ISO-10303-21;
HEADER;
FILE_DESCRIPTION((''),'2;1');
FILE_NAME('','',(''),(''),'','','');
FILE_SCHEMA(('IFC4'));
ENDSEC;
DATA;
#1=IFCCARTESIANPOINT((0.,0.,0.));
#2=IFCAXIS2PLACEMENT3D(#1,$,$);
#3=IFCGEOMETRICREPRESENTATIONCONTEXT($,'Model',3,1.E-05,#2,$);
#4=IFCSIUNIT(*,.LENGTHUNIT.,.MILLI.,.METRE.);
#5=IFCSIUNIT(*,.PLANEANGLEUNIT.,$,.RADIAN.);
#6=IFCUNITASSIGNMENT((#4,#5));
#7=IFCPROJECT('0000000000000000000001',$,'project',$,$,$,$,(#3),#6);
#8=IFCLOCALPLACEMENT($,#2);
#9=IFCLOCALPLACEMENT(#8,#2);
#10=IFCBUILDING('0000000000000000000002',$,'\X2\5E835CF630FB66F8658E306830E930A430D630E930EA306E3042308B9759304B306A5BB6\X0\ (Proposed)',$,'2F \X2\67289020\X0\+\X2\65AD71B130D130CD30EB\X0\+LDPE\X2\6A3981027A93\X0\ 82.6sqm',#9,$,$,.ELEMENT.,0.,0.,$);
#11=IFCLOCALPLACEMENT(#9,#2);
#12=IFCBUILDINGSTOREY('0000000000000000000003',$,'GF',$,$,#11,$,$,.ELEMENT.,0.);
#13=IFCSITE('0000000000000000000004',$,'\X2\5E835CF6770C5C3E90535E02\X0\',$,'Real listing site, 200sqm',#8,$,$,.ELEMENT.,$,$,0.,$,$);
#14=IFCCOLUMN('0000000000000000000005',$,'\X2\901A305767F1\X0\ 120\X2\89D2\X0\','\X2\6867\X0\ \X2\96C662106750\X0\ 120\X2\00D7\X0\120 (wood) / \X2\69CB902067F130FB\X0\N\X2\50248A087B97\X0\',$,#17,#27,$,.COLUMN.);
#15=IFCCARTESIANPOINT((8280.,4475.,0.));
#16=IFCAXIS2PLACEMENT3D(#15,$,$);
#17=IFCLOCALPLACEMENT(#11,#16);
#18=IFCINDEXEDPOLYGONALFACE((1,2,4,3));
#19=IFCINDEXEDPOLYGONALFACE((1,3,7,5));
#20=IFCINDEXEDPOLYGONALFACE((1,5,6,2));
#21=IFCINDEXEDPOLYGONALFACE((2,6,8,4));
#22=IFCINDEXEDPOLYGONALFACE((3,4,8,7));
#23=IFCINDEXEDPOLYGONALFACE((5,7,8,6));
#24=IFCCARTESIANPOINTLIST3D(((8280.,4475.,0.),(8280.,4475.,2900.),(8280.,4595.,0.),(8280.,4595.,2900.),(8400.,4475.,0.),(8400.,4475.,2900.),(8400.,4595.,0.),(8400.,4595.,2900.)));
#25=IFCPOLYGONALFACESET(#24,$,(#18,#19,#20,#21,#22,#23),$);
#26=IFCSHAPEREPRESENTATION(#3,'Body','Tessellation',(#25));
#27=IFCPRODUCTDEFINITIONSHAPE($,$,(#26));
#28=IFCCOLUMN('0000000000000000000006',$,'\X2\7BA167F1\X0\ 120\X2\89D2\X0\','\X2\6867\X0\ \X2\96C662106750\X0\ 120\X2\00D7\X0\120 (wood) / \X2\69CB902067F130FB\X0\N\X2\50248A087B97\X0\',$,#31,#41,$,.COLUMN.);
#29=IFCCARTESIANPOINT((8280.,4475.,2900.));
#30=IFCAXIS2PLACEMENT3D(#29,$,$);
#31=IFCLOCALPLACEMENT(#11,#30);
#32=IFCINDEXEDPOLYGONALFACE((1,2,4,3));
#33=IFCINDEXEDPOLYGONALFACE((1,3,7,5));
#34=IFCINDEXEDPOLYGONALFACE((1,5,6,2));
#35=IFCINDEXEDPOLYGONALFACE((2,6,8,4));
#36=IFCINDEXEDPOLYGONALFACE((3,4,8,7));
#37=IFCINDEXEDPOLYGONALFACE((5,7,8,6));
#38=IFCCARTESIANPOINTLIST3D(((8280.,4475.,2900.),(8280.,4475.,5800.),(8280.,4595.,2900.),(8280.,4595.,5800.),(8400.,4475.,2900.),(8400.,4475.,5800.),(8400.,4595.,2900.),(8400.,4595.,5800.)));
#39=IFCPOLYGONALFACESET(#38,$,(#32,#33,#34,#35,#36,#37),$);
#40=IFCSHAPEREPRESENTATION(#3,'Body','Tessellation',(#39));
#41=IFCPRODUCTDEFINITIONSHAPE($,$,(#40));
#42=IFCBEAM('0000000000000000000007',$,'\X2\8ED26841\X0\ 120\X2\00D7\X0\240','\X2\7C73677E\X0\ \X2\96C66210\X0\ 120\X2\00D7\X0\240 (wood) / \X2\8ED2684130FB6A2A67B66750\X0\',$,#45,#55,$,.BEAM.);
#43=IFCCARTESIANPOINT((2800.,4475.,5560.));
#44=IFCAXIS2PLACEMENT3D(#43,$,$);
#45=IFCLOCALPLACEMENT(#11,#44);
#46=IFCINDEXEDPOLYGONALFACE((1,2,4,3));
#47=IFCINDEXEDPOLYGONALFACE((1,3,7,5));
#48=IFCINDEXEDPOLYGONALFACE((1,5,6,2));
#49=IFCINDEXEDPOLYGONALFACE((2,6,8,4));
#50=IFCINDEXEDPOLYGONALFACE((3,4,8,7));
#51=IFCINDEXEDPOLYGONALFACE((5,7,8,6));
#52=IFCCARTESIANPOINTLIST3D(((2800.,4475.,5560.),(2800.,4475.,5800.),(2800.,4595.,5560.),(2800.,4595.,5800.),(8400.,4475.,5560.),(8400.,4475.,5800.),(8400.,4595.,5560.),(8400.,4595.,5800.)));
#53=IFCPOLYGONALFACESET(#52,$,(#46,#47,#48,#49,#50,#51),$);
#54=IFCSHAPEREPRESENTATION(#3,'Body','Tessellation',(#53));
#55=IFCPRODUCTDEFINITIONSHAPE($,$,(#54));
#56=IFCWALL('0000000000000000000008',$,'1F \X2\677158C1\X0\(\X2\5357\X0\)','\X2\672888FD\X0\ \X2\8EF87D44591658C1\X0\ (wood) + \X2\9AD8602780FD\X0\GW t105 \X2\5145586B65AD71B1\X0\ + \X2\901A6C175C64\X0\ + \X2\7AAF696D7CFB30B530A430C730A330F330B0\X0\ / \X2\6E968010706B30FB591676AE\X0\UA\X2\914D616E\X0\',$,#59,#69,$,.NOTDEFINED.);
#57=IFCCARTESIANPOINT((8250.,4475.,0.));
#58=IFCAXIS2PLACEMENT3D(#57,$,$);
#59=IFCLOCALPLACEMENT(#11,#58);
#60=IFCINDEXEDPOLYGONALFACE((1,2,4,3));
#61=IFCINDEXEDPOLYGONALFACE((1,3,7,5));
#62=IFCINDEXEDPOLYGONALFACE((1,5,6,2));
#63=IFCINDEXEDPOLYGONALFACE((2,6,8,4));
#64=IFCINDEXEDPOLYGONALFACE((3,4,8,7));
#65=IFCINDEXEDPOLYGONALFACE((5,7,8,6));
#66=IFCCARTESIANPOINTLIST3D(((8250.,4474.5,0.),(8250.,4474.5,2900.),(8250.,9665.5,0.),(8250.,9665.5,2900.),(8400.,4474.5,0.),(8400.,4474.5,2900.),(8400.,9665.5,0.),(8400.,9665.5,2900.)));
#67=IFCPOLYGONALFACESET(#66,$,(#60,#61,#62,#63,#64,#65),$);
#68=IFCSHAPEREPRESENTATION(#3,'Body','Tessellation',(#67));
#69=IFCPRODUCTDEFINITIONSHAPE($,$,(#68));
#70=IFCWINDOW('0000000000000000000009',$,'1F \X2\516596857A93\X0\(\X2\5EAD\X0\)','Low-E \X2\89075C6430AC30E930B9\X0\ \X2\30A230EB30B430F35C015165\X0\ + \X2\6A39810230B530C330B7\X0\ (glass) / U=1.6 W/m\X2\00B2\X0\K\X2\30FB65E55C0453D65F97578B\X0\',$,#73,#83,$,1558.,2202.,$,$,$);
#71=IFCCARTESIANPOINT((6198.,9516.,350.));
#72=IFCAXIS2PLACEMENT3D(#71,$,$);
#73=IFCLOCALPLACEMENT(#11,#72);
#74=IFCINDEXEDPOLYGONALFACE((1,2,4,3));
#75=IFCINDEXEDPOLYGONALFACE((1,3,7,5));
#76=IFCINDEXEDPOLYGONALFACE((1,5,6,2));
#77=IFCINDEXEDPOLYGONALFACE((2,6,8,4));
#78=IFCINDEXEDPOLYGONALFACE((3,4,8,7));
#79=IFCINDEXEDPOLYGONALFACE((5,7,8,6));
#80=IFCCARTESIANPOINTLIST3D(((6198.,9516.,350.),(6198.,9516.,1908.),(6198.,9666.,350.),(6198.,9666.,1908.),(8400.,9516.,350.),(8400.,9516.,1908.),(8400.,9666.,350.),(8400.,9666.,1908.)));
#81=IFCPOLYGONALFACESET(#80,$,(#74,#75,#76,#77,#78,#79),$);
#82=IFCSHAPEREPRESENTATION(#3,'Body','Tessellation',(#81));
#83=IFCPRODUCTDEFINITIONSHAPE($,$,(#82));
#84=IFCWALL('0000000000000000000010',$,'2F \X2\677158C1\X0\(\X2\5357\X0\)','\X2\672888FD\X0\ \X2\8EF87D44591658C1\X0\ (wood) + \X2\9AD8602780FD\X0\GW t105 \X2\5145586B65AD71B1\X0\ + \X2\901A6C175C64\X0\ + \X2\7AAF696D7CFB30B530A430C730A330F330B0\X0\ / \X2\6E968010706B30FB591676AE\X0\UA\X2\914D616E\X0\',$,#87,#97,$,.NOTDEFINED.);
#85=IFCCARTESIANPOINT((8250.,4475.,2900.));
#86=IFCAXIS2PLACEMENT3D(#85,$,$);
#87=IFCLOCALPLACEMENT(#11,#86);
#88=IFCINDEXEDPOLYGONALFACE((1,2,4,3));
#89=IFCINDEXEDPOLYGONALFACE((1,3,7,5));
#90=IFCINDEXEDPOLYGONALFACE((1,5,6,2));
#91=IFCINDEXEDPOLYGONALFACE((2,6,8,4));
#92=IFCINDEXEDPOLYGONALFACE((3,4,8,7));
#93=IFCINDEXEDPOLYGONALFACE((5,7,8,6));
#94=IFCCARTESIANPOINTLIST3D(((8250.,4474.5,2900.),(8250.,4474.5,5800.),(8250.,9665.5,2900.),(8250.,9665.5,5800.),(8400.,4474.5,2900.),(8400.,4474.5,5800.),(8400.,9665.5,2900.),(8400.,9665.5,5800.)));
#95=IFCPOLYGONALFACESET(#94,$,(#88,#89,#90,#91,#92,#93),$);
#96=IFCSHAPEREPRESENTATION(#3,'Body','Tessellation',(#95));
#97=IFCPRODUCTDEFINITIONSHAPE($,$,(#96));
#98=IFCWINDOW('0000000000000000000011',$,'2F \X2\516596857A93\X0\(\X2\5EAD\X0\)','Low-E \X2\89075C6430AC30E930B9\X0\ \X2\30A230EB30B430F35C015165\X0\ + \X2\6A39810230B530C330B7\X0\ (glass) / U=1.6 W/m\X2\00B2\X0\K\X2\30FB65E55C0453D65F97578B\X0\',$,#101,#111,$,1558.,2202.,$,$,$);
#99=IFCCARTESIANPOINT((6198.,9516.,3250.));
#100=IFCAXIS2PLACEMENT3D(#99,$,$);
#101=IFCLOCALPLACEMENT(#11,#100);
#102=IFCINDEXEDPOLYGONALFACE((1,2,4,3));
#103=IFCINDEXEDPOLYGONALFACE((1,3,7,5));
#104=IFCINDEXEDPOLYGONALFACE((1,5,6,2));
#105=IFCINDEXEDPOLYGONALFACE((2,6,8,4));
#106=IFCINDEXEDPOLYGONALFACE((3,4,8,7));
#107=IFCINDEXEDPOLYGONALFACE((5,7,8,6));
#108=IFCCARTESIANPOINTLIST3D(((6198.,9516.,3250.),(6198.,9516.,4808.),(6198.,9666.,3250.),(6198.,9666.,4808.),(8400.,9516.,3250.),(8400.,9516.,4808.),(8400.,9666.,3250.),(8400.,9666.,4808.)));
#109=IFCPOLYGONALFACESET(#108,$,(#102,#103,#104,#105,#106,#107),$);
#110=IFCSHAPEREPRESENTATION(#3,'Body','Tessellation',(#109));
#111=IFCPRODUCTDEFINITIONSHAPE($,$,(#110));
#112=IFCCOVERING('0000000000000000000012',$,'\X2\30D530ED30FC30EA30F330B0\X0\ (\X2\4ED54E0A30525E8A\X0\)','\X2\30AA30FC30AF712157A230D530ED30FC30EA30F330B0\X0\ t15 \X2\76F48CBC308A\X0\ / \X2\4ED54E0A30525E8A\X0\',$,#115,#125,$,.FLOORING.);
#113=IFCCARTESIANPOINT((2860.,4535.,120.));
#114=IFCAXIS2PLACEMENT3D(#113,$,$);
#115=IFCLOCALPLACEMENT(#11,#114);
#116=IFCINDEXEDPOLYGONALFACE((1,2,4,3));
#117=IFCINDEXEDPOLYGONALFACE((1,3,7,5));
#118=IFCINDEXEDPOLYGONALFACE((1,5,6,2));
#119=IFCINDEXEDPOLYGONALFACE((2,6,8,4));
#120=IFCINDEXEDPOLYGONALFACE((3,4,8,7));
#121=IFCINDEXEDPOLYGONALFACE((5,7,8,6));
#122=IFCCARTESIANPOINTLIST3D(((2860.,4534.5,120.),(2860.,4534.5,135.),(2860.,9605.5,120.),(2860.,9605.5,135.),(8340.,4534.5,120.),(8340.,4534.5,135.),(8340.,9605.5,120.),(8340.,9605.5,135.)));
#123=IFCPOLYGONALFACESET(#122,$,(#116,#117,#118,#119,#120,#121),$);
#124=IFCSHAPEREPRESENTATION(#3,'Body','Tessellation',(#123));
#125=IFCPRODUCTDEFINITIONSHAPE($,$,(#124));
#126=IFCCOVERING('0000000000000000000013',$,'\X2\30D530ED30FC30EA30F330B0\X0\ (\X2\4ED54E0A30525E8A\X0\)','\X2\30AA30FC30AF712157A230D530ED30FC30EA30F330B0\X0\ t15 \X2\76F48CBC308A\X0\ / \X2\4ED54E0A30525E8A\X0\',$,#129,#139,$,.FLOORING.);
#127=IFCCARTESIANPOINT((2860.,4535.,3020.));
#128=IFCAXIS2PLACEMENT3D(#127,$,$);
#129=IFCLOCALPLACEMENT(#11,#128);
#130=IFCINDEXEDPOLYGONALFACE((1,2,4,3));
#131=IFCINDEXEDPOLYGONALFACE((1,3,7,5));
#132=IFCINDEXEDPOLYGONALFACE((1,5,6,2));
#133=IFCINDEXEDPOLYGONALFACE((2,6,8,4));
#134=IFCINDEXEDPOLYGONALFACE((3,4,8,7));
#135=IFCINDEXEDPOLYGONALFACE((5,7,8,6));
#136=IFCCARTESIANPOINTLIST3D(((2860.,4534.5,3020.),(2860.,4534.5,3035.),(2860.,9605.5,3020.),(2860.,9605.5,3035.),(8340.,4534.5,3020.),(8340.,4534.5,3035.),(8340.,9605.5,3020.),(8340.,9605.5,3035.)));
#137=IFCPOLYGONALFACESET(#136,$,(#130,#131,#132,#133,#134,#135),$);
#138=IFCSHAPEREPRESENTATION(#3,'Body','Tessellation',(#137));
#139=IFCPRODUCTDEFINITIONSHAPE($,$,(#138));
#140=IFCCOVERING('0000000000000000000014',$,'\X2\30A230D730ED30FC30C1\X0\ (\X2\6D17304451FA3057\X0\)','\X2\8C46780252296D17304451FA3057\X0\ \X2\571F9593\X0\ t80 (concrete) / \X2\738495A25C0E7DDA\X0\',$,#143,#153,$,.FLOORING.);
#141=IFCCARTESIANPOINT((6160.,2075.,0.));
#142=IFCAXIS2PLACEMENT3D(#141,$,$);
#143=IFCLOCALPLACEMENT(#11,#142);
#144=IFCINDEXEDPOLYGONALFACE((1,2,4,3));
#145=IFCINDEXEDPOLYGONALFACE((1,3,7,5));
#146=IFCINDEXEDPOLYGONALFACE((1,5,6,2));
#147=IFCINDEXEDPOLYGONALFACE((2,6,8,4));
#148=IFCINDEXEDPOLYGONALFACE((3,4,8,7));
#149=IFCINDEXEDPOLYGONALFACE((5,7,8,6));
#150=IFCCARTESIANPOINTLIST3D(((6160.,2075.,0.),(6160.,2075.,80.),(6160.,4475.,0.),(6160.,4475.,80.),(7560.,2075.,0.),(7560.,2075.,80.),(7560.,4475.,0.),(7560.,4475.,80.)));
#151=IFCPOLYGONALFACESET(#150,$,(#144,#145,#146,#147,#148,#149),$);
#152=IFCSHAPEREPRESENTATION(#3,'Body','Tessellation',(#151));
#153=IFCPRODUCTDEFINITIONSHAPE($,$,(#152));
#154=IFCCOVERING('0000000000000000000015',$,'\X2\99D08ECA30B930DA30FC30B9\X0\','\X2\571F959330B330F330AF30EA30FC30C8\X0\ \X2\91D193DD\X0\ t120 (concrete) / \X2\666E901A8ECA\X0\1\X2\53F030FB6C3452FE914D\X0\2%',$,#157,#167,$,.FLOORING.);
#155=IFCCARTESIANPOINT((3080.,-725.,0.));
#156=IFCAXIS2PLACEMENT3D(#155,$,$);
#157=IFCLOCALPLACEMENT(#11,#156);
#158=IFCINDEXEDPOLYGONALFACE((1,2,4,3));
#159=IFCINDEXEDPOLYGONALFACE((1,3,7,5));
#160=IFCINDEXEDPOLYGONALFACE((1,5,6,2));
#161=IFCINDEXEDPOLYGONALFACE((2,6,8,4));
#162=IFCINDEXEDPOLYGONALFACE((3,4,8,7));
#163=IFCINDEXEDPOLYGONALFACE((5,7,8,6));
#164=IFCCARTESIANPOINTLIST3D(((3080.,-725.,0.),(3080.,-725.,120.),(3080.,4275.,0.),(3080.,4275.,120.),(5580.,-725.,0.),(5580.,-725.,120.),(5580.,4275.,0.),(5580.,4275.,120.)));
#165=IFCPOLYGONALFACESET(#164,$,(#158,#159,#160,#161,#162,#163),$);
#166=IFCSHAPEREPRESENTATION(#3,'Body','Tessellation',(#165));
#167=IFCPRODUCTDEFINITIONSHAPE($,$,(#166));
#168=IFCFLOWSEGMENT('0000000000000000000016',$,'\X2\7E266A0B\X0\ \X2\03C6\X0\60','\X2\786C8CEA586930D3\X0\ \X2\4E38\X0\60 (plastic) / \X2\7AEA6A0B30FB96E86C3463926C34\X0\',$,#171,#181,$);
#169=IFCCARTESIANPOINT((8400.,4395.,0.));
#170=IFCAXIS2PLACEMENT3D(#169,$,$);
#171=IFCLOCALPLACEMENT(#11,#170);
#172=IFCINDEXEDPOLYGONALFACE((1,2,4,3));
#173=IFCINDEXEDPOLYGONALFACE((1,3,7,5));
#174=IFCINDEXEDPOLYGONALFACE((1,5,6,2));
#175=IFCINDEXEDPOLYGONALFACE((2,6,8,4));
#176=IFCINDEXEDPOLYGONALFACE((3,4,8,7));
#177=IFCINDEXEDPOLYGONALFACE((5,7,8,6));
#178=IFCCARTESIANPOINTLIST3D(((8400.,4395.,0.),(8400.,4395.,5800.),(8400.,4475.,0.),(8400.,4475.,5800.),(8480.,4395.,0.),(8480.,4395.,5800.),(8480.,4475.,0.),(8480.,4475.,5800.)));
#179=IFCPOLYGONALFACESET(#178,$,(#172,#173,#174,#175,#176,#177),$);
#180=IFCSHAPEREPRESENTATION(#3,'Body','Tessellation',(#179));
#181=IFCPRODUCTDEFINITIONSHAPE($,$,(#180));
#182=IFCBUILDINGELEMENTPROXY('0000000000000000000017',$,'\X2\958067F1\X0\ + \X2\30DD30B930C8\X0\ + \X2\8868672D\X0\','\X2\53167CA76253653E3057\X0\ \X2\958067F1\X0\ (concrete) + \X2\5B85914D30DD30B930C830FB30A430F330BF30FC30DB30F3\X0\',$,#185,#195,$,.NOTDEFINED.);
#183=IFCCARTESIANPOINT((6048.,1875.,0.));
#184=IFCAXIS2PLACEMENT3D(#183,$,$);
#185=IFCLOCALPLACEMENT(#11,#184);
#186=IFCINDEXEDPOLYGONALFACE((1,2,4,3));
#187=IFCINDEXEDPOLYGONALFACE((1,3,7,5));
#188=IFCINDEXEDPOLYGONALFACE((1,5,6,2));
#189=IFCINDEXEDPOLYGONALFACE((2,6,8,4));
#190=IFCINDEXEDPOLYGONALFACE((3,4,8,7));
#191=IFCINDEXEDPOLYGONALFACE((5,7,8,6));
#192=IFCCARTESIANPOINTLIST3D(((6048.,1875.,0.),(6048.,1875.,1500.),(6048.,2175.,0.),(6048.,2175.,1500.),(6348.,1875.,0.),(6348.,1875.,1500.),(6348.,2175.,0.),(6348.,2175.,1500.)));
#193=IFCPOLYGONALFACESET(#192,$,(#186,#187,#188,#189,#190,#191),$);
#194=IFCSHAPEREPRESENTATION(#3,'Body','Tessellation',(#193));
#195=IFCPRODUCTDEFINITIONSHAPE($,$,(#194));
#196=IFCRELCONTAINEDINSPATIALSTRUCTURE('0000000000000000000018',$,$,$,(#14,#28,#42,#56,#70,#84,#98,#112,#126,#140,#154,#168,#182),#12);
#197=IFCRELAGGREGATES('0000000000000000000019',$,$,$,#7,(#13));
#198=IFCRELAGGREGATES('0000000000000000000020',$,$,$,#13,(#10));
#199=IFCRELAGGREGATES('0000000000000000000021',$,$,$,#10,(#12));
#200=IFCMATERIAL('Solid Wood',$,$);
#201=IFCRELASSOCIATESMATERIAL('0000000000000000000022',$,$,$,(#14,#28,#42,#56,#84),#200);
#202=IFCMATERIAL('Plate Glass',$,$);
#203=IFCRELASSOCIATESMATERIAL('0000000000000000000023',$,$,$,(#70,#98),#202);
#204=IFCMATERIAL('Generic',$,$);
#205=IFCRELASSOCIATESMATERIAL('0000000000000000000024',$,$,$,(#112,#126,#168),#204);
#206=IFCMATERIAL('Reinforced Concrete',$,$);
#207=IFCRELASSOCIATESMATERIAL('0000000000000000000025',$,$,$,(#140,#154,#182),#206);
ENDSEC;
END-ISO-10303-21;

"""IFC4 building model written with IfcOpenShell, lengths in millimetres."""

from ifc_helpers import new_model, si_unit, frame, frame_2d, origin, place, context, project, spatial, rectangle, extrude, material, element, fill, save


model = new_model("IFC4")

# Units and contexts
model_context = context("Model", 3, precision=1e-05, world=origin())
ifc_project = project(units=[si_unit("LENGTHUNIT", "METRE", prefix="MILLI"), si_unit("PLANEANGLEUNIT", "RADIAN")], contexts=[model_context])

# Site, building, storey
site_placement = place(None, origin())
site = spatial("IfcSite", under=ifc_project, at=site_placement, Name="広島県尾道市", ObjectType="Real listing site, 200sqm", CompositionType="ELEMENT", RefElevation=0.0)
building_placement = place(site_placement, origin())
building = spatial("IfcBuilding", under=site, at=building_placement, Name="広島・書斎とライブラリのある静かな家 (Proposed)", ObjectType="2F 木造+断熱パネル+LDPE樹脂窓 82.6sqm", CompositionType="ELEMENT", ElevationOfRefHeight=0.0, ElevationOfTerrain=0.0)
storey_placement = place(building_placement, origin())
storey = spatial("IfcBuildingStorey", under=building, at=storey_placement, Name="GF", CompositionType="ELEMENT", Elevation=0.0)

# Columns
ifc_material_1 = material(Name="Solid Wood")
column_1_placement = place(storey_placement, frame((8280.0, 4475.0, 0.0)))
element("IfcColumn", 1, at=column_1_placement, inside=storey, material=ifc_material_1, Name="通し柱 120角", Description="桧 集成材 120×120 (wood) / 構造柱・N値計算", PredefinedType="COLUMN", context=model_context, shape_type="SweptSolid", body=[
    extrude(rectangle(XDim=120.0, YDim=120.0, at=frame_2d((60.0, 60.0))), frame((8280.0, 4475.0, 0.0)), (0.0, 0.0, 1.0), 2900.0),
])
column_2_placement = place(storey_placement, frame((8280.0, 4475.0, 2900.0)))
element("IfcColumn", 2, at=column_2_placement, inside=storey, material=ifc_material_1, Name="管柱 120角", Description="桧 集成材 120×120 (wood) / 構造柱・N値計算", PredefinedType="COLUMN", context=model_context, shape_type="SweptSolid", body=[
    extrude(rectangle(XDim=120.0, YDim=120.0, at=frame_2d((60.0, 60.0))), frame((8280.0, 4475.0, 2900.0)), (0.0, 0.0, 1.0), 2900.0),
])

# Beam
beam_1_placement = place(storey_placement, frame((2800.0, 4475.0, 5560.0)))
element("IfcBeam", 3, at=beam_1_placement, inside=storey, material=ifc_material_1, Name="軒桁 120×240", Description="米松 集成 120×240 (wood) / 軒桁・横架材", PredefinedType="BEAM", context=model_context, shape_type="SweptSolid", body=[
    extrude(rectangle(XDim=5600.0, YDim=120.0, at=frame_2d((2800.0, 60.0))), frame((2800.0, 4475.0, 5560.0)), (0.0, 0.0, 1.0), 240.0),
])

# Wall, opening, window
wall_1_placement = place(storey_placement, frame((8250.0, 4475.0, 0.0)))
wall_1 = element("IfcWall", 4, at=wall_1_placement, inside=storey, material=ifc_material_1, Name="1F 東壁(南)", Description="木製 軸組外壁 (wood) + 高性能GW t105 充填断熱 + 通気層 + 窯業系サイディング / 準耐火・外皮UA配慮", PredefinedType="NOTDEFINED", context=model_context, shape_type="SweptSolid", body=[
    extrude(rectangle(XDim=150.0, YDim=5191.0, at=frame_2d((75.0, 2595.0))), frame((8250.0, 4475.0, 0.0)), (0.0, 0.0, 1.0), 2900.0),
])
opening_1_placement = place(storey_placement, frame((6198.0, 9516.0, 350.0)))
opening_1 = element("IfcOpeningElement", 5, at=opening_1_placement, cuts=wall_1, PredefinedType="NOTDEFINED", context=model_context, shape_type="SweptSolid", body=[
    extrude(rectangle(XDim=2202.0, YDim=150.0, at=frame_2d((1101.0, 75.0))), frame((6198.0, 9516.0, 350.0)), (0.0, 0.0, 1.0), 1558.0),
])
ifc_material_2 = material(Name="Plate Glass")
window_1_placement = place(storey_placement, frame((6198.0, 9516.0, 350.0)))
window_1 = element("IfcWindow", 6, at=window_1_placement, inside=storey, material=ifc_material_2, Name="1F 入隅窓(庭)", Description="Low-E 複層ガラス アルゴン封入 + 樹脂サッシ (glass) / U=1.6 W/m²K・日射取得型", OverallHeight=1558.0, OverallWidth=2202.0, context=model_context, shape_type="SweptSolid", body=[
    extrude(rectangle(XDim=2202.0, YDim=150.0, at=frame_2d((1101.0, 75.0))), frame((6198.0, 9516.0, 350.0)), (0.0, 0.0, 1.0), 1558.0),
])
fill(opening_1, window_1)

# Wall, opening, window
wall_2_placement = place(storey_placement, frame((8250.0, 4475.0, 2900.0)))
wall_2 = element("IfcWall", 7, at=wall_2_placement, inside=storey, material=ifc_material_1, Name="2F 東壁(南)", Description="木製 軸組外壁 (wood) + 高性能GW t105 充填断熱 + 通気層 + 窯業系サイディング / 準耐火・外皮UA配慮", PredefinedType="NOTDEFINED", context=model_context, shape_type="SweptSolid", body=[
    extrude(rectangle(XDim=150.0, YDim=5191.0, at=frame_2d((75.0, 2595.0))), frame((8250.0, 4475.0, 2900.0)), (0.0, 0.0, 1.0), 2900.0),
])
opening_2_placement = place(storey_placement, frame((6198.0, 9516.0, 3250.0)))
opening_2 = element("IfcOpeningElement", 8, at=opening_2_placement, cuts=wall_2, PredefinedType="NOTDEFINED", context=model_context, shape_type="SweptSolid", body=[
    extrude(rectangle(XDim=2202.0, YDim=150.0, at=frame_2d((1101.0, 75.0))), frame((6198.0, 9516.0, 3250.0)), (0.0, 0.0, 1.0), 1558.0),
])
window_2_placement = place(storey_placement, frame((6198.0, 9516.0, 3250.0)))
window_2 = element("IfcWindow", 9, at=window_2_placement, inside=storey, material=ifc_material_2, Name="2F 入隅窓(庭)", Description="Low-E 複層ガラス アルゴン封入 + 樹脂サッシ (glass) / U=1.6 W/m²K・日射取得型", OverallHeight=1558.0, OverallWidth=2202.0, context=model_context, shape_type="SweptSolid", body=[
    extrude(rectangle(XDim=2202.0, YDim=150.0, at=frame_2d((1101.0, 75.0))), frame((6198.0, 9516.0, 3250.0)), (0.0, 0.0, 1.0), 1558.0),
])
fill(opening_2, window_2)

# Coverings
ifc_material_3 = material(Name="Generic")
covering_1_placement = place(storey_placement, frame((2860.0, 4535.0, 120.0)))
element("IfcCovering", 10, at=covering_1_placement, inside=storey, material=ifc_material_3, Name="フローリング (仕上げ床)", Description="オーク無垢フローリング t15 直貼り / 仕上げ床", PredefinedType="FLOORING", context=model_context, shape_type="SweptSolid", body=[
    extrude(rectangle(XDim=5480.0, YDim=5071.0, at=frame_2d((2740.0, 2535.0))), frame((2860.0, 4535.0, 120.0)), (0.0, 0.0, 1.0), 15.0),
])
covering_2_placement = place(storey_placement, frame((2860.0, 4535.0, 3020.0)))
element("IfcCovering", 11, at=covering_2_placement, inside=storey, material=ifc_material_3, Name="フローリング (仕上げ床)", Description="オーク無垢フローリング t15 直貼り / 仕上げ床", PredefinedType="FLOORING", context=model_context, shape_type="SweptSolid", body=[
    extrude(rectangle(XDim=5480.0, YDim=5071.0, at=frame_2d((2740.0, 2535.0))), frame((2860.0, 4535.0, 3020.0)), (0.0, 0.0, 1.0), 15.0),
])
ifc_material_4 = material(Name="Reinforced Concrete")
covering_3_placement = place(storey_placement, frame((6160.0, 2075.0, 0.0)))
element("IfcCovering", 12, at=covering_3_placement, inside=storey, material=ifc_material_4, Name="アプローチ (洗い出し)", Description="豆砂利洗い出し 土間 t80 (concrete) / 玄関導線", PredefinedType="FLOORING", context=model_context, shape_type="SweptSolid", body=[
    extrude(rectangle(XDim=1400.0, YDim=2400.0, at=frame_2d((700.0, 1200.0))), frame((6160.0, 2075.0, 0.0)), (0.0, 0.0, 1.0), 80.0),
])
covering_4_placement = place(storey_placement, frame((3080.0, -725.0, 0.0)))
element("IfcCovering", 13, at=covering_4_placement, inside=storey, material=ifc_material_4, Name="駐車スペース", Description="土間コンクリート 金鏝 t120 (concrete) / 普通車1台・水勾配2%", PredefinedType="FLOORING", context=model_context, shape_type="SweptSolid", body=[
    extrude(rectangle(XDim=2500.0, YDim=5000.0, at=frame_2d((1250.0, 2500.0))), frame((3080.0, -725.0, 0.0)), (0.0, 0.0, 1.0), 120.0),
])

# Flow segment
flow_segment_placement = place(storey_placement, frame((8400.0, 4395.0, 0.0)))
element("IfcFlowSegment", 14, at=flow_segment_placement, inside=storey, material=ifc_material_3, Name="縦樋 φ60", Description="硬質塩ビ 丸60 (plastic) / 竪樋・雨水排水", context=model_context, shape_type="SweptSolid", body=[
    extrude(rectangle(XDim=80.0, YDim=80.0, at=frame_2d((40.0, 40.0))), frame((8400.0, 4395.0, 0.0)), (0.0, 0.0, 1.0), 5800.0),
])

# Building element proxy
proxy_placement = place(storey_placement, frame((6048.0, 1875.0, 0.0)))
element("IfcBuildingElementProxy", 15, at=proxy_placement, inside=storey, material=ifc_material_4, Name="門柱 + ポスト + 表札", Description="化粧打放し 門柱 (concrete) + 宅配ポスト・インターホン", PredefinedType="NOTDEFINED", context=model_context, shape_type="SweptSolid", body=[
    extrude(rectangle(XDim=300.0, YDim=300.0, at=frame_2d((150.0, 150.0))), frame((6048.0, 1875.0, 0.0)), (0.0, 0.0, 1.0), 1500.0),
])

save(model, "model.ifc")
